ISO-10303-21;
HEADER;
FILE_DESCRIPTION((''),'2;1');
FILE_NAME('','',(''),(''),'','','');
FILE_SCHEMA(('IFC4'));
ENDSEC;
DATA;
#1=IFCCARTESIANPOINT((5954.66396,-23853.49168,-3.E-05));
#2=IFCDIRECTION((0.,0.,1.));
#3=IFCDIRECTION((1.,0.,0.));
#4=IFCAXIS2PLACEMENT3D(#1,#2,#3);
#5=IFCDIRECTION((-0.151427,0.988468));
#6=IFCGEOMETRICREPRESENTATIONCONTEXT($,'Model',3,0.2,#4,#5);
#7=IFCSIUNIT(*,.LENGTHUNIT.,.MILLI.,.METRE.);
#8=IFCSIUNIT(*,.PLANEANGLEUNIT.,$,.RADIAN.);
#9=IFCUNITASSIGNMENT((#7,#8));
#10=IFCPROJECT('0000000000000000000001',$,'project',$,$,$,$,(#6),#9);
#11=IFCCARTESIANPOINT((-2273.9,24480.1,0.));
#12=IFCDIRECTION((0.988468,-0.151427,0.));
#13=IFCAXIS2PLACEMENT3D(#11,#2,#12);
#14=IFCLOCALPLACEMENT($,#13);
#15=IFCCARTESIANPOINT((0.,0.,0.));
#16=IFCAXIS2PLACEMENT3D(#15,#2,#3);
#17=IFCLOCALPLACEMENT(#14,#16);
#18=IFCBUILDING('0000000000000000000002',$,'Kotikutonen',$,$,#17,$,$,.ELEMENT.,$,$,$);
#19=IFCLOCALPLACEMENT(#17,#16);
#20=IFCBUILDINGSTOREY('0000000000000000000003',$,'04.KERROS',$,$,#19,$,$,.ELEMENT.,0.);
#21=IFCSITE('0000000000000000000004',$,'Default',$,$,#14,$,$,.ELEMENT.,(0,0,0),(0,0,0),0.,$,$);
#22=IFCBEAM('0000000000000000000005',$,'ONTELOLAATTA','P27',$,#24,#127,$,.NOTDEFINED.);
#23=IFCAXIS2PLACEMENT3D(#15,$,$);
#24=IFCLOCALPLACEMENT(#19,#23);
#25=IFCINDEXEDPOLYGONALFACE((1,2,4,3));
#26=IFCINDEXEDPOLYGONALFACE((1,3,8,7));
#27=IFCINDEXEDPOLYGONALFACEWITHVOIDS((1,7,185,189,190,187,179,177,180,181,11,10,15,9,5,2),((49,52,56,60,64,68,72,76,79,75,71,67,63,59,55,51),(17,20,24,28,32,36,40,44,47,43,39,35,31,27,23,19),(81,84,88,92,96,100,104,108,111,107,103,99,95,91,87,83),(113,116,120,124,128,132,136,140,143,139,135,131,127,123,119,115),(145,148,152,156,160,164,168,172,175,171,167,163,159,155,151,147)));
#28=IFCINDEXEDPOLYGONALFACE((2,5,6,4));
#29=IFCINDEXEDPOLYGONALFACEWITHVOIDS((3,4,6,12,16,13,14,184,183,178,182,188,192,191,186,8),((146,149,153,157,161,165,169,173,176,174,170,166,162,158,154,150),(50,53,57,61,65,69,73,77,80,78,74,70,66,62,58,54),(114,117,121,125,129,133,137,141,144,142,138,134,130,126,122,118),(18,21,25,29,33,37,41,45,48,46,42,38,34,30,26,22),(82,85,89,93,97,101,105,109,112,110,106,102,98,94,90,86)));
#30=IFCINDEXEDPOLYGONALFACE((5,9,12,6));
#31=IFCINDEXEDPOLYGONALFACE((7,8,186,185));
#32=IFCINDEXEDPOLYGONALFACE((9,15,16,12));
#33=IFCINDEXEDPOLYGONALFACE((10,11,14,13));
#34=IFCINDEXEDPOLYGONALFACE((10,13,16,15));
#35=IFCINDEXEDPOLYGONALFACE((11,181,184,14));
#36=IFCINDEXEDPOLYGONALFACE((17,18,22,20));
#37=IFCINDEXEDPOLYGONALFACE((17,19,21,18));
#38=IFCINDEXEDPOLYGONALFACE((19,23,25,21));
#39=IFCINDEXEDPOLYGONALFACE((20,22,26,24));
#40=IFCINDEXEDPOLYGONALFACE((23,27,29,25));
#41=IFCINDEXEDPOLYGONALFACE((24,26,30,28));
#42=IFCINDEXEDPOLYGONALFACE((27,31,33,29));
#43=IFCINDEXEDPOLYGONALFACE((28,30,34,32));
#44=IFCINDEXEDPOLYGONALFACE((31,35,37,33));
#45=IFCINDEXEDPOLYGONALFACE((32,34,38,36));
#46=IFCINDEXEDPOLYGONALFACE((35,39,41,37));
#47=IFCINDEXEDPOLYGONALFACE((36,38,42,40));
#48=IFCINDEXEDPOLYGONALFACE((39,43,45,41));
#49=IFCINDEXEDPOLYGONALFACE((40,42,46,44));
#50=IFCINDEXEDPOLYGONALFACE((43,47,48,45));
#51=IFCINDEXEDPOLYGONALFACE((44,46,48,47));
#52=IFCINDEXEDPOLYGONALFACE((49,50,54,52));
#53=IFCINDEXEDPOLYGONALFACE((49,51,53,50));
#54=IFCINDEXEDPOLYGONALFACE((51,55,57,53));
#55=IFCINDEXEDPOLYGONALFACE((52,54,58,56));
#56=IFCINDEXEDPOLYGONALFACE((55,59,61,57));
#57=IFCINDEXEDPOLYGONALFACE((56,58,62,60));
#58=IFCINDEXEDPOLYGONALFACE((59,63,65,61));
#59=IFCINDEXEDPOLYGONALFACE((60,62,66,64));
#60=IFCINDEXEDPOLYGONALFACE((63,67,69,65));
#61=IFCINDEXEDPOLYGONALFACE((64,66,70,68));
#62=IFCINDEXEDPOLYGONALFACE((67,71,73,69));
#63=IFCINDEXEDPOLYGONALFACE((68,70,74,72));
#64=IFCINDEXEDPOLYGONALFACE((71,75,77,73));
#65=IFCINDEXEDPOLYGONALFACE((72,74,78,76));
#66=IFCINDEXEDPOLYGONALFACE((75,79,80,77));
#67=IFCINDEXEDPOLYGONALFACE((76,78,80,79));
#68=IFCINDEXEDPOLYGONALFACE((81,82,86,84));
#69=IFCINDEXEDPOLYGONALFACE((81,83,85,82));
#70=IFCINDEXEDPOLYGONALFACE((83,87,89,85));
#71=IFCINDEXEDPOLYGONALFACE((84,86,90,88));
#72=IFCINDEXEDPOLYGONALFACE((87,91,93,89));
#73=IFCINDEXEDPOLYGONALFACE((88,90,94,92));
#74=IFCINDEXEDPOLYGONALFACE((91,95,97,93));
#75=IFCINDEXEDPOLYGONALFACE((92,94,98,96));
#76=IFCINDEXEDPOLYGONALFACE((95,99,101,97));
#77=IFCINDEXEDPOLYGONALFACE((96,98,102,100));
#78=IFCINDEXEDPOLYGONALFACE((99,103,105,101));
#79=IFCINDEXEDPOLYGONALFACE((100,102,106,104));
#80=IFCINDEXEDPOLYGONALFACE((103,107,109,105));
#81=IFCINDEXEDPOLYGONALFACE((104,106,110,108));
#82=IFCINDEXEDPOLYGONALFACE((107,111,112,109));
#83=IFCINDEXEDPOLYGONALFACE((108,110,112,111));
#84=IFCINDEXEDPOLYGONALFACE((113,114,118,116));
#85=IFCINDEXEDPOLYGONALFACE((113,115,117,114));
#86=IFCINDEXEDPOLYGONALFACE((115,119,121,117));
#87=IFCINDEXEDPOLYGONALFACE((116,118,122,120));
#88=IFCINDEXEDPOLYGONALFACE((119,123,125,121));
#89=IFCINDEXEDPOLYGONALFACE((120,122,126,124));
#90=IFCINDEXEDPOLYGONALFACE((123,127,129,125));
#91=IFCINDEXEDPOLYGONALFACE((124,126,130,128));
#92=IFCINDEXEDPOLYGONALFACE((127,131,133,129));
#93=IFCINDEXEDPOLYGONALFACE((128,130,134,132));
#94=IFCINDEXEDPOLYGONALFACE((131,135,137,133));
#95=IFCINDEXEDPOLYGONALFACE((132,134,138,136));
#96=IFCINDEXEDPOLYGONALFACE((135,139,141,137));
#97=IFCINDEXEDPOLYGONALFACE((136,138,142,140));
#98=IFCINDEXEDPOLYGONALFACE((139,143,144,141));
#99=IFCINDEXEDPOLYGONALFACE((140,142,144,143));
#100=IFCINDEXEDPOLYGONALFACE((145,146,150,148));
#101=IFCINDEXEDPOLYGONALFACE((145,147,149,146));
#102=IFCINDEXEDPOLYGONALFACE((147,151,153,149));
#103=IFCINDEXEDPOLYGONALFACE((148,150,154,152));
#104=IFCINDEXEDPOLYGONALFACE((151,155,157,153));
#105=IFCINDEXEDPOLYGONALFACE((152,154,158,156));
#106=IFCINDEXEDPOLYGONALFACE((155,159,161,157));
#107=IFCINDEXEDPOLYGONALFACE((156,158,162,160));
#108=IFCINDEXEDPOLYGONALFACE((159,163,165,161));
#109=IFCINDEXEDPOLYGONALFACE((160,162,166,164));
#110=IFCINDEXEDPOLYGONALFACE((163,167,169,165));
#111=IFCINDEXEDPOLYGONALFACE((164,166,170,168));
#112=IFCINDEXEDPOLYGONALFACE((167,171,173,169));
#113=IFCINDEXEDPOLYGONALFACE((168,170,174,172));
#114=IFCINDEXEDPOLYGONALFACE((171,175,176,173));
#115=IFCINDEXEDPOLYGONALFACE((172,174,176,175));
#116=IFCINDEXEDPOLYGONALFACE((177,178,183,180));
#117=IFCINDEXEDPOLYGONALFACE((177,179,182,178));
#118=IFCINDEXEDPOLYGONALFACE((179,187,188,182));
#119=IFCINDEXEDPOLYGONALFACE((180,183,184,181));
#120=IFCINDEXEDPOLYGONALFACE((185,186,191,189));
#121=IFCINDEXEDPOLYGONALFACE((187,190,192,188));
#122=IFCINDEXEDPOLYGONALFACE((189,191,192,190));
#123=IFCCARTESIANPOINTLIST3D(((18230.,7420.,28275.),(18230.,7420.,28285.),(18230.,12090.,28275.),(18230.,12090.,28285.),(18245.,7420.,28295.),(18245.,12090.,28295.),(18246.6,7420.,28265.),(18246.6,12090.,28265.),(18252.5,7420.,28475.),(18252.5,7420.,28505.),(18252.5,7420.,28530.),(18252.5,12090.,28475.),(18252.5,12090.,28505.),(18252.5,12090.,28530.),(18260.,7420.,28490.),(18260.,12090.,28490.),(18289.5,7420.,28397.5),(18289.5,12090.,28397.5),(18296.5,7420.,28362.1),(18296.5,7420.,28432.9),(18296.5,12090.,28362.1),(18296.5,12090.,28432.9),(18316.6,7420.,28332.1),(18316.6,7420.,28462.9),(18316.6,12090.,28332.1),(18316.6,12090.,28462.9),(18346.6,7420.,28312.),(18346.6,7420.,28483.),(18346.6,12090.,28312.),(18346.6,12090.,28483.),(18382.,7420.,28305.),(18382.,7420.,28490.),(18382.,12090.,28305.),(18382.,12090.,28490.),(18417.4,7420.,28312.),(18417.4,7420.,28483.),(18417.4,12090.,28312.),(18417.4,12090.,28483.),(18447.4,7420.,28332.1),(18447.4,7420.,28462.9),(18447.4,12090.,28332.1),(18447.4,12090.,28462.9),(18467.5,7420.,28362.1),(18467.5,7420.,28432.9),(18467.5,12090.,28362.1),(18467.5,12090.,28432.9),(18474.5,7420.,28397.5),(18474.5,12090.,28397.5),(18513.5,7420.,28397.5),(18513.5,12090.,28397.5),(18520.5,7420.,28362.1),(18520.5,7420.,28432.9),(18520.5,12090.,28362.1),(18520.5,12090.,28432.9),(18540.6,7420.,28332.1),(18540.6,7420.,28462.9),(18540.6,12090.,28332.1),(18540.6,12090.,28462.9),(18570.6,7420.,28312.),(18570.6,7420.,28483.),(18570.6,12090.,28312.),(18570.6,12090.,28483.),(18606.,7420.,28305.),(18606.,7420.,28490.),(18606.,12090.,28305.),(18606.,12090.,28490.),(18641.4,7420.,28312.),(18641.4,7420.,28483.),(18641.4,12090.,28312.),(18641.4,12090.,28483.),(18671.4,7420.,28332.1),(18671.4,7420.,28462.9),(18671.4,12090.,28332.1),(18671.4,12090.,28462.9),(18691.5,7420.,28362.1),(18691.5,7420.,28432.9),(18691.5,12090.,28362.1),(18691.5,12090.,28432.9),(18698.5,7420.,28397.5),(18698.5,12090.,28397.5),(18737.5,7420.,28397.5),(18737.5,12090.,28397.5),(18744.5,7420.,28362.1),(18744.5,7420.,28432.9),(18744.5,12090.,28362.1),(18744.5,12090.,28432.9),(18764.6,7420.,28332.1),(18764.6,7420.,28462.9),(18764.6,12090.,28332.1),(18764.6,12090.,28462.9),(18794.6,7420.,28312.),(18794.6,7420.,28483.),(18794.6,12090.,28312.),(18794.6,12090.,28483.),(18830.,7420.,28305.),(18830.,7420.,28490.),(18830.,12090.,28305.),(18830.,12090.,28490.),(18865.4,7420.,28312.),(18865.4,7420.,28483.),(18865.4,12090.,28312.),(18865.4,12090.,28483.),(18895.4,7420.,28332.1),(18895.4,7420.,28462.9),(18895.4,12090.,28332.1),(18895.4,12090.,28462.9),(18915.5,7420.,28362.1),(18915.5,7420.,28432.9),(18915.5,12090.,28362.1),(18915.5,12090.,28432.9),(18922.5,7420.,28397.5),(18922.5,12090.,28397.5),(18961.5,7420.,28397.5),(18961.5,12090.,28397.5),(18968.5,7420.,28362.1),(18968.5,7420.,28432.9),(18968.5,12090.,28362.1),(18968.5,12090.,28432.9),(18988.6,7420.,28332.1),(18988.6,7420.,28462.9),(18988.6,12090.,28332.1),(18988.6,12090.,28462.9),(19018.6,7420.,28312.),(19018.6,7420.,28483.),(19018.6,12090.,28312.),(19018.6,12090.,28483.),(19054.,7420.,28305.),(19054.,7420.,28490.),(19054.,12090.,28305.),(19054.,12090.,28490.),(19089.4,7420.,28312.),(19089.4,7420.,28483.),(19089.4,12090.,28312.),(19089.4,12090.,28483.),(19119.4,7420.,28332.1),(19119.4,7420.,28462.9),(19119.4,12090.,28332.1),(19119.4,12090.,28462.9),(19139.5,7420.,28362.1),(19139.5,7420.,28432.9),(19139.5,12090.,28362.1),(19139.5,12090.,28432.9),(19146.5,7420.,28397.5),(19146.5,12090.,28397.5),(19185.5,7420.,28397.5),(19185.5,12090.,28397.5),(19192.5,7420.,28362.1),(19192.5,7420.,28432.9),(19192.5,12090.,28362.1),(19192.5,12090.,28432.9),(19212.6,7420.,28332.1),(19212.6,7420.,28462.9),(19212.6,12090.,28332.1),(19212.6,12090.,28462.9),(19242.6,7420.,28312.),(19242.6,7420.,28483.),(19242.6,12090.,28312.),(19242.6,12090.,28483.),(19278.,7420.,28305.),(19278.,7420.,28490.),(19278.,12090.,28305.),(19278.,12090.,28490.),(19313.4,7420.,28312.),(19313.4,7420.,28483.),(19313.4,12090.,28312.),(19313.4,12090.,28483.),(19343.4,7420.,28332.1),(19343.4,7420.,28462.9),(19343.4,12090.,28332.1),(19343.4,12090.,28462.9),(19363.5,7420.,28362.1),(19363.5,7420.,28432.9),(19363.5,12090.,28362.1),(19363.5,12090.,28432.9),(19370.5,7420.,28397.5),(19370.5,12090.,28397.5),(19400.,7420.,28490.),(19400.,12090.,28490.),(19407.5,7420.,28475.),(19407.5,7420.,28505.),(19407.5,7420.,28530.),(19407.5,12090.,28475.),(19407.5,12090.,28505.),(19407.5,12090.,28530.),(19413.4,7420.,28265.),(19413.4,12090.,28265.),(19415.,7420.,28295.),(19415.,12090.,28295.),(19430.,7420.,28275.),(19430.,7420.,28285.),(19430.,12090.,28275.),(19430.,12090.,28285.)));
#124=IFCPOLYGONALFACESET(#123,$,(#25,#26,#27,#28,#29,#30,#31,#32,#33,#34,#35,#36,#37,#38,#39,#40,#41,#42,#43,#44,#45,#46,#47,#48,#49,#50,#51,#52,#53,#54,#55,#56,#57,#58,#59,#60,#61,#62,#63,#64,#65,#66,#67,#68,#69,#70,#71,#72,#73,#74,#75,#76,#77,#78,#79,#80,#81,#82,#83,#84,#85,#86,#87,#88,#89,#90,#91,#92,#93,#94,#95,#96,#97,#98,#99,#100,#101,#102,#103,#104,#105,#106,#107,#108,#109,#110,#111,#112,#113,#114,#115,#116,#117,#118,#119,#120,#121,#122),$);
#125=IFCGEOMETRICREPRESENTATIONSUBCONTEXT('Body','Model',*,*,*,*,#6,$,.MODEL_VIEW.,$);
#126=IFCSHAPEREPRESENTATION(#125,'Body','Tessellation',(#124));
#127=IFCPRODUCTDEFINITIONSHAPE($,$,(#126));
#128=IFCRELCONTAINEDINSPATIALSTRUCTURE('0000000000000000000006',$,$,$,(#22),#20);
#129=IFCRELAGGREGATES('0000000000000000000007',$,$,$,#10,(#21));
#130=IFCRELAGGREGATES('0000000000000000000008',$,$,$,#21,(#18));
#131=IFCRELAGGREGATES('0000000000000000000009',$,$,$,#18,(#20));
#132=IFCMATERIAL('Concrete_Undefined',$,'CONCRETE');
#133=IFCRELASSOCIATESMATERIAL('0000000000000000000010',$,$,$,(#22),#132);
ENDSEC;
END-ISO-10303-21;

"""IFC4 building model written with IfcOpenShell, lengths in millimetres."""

from ifc_helpers import new_model, si_unit, direction, frame, origin_with_axes, place, context, subcontext, project, spatial, line, indexed_curve, outline, extrude, material, element, save


model = new_model("IFC4")

# Units and contexts
model_context = context("Model", 3, precision=0.2, world=frame((5954.66396, -23853.49168, -3e-05), z_axis=(0.0, 0.0, 1.0), x_axis=(1.0, 0.0, 0.0)), true_north=direction((-0.151427, 0.988468)))
body_context = subcontext(model_context, "Body", "Model", "MODEL_VIEW")
ifc_project = project(units=[si_unit("LENGTHUNIT", "METRE", prefix="MILLI"), si_unit("PLANEANGLEUNIT", "RADIAN")], contexts=[model_context])

# Site, building, storey
site_placement = place(None, frame((-2273.9, 24480.1, 0.0), z_axis=(0.0, 0.0, 1.0), x_axis=(0.988468, -0.151427, 0.0)))
site = spatial("IfcSite", under=ifc_project, at=site_placement, Name="Default", CompositionType="ELEMENT", RefLatitude=(0, 0, 0), RefLongitude=(0, 0, 0), RefElevation=0.0)
building_placement = place(site_placement, origin_with_axes())
building = spatial("IfcBuilding", under=site, at=building_placement, Name="Kotikutonen", CompositionType="ELEMENT")
storey_placement = place(building_placement, origin_with_axes())
storey = spatial("IfcBuildingStorey", under=building, at=storey_placement, Name="04.KERROS", CompositionType="ELEMENT", Elevation=0.0)

# Beam
ifc_material_1 = material(Name="Concrete_Undefined", Category="CONCRETE")
beam_1_placement = place(storey_placement, frame((18830.0, 12090.0, 28397.5), z_axis=(-1.0, 0.0, 0.0), x_axis=(0.0, -1.0, 0.0)))
element("IfcBeam", 1, at=beam_1_placement, inside=storey, material=ifc_material_1, Name="ONTELOLAATTA", Description="P27", PredefinedType="NOTDEFINED", context=body_context, shape_type="SolidModel", body=[
    extrude(outline(indexed_curve([(-600.0, -122.5), (-583.4, -132.5), (583.4, -132.5), (600.0, -122.5), (600.0, -112.5), (585.0, -102.5), (577.5, 77.5), (570.0, 92.5), (577.5, 107.5), (577.5, 132.5), (-577.5, 132.5), (-577.5, 107.5), (-570.0, 92.5), (-577.5, 77.5), (-585.0, -102.5), (-600.0, -112.5)], segments=[line(1, 2, 3, 4, 5, 6, 7, 8, 9, 10, 11, 12, 13, 14, 15, 16, 1)]), holes=[indexed_curve([(-448.0, -92.5), (-483.4, -85.5), (-513.4, -65.4), (-533.5, -35.4), (-540.5, 0.0), (-533.5, 35.4), (-513.4, 65.4), (-483.4, 85.5), (-448.0, 92.5), (-412.6, 85.5), (-382.6, 65.4), (-362.5, 35.4), (-355.5, 0.0), (-362.5, -35.4), (-382.6, -65.4), (-412.6, -85.5)], segments=[line(1, 2, 3, 4, 5, 6, 7, 8, 9, 10, 11, 12, 13, 14, 15, 16, 1)]), indexed_curve([(-224.0, -92.5), (-259.4, -85.5), (-289.4, -65.4), (-309.5, -35.4), (-316.5, 0.0), (-309.5, 35.4), (-289.4, 65.4), (-259.4, 85.5), (-224.0, 92.5), (-188.6, 85.5), (-158.6, 65.4), (-138.5, 35.4), (-131.5, 0.0), (-138.5, -35.4), (-158.6, -65.4), (-188.6, -85.5)], segments=[line(1, 2, 3, 4, 5, 6, 7, 8, 9, 10, 11, 12, 13, 14, 15, 16, 1)]), indexed_curve([(0.0, -92.5), (-35.4, -85.5), (-65.4, -65.4), (-85.5, -35.4), (-92.5, 0.0), (-85.5, 35.4), (-65.4, 65.4), (-35.4, 85.5), (0.0, 92.5), (35.4, 85.5), (65.4, 65.4), (85.5, 35.4), (92.5, 0.0), (85.5, -35.4), (65.4, -65.4), (35.4, -85.5)], segments=[line(1, 2, 3, 4, 5, 6, 7, 8, 9, 10, 11, 12, 13, 14, 15, 16, 1)]), indexed_curve([(224.0, -92.5), (188.6, -85.5), (158.6, -65.4), (138.5, -35.4), (131.5, 0.0), (138.5, 35.4), (158.6, 65.4), (188.6, 85.5), (224.0, 92.5), (259.4, 85.5), (289.4, 65.4), (309.5, 35.4), (316.5, 0.0), (309.5, -35.4), (289.4, -65.4), (259.4, -85.5)], segments=[line(1, 2, 3, 4, 5, 6, 7, 8, 9, 10, 11, 12, 13, 14, 15, 16, 1)]), indexed_curve([(448.0, -92.5), (412.6, -85.5), (382.6, -65.4), (362.5, -35.4), (355.5, 0.0), (362.5, 35.4), (382.6, 65.4), (412.6, 85.5), (448.0, 92.5), (483.4, 85.5), (513.4, 65.4), (533.5, 35.4), (540.5, 0.0), (533.5, -35.4), (513.4, -65.4), (483.4, -85.5)], segments=[line(1, 2, 3, 4, 5, 6, 7, 8, 9, 10, 11, 12, 13, 14, 15, 16, 1)])]), frame((0.0, 0.0, 0.0), z_axis=(-1.0, 0.0, 0.0), x_axis=(0.0, 0.0, 1.0)), (0.0, 0.0, -1.0), 4670.0),
])

save(model, "model.ifc")
